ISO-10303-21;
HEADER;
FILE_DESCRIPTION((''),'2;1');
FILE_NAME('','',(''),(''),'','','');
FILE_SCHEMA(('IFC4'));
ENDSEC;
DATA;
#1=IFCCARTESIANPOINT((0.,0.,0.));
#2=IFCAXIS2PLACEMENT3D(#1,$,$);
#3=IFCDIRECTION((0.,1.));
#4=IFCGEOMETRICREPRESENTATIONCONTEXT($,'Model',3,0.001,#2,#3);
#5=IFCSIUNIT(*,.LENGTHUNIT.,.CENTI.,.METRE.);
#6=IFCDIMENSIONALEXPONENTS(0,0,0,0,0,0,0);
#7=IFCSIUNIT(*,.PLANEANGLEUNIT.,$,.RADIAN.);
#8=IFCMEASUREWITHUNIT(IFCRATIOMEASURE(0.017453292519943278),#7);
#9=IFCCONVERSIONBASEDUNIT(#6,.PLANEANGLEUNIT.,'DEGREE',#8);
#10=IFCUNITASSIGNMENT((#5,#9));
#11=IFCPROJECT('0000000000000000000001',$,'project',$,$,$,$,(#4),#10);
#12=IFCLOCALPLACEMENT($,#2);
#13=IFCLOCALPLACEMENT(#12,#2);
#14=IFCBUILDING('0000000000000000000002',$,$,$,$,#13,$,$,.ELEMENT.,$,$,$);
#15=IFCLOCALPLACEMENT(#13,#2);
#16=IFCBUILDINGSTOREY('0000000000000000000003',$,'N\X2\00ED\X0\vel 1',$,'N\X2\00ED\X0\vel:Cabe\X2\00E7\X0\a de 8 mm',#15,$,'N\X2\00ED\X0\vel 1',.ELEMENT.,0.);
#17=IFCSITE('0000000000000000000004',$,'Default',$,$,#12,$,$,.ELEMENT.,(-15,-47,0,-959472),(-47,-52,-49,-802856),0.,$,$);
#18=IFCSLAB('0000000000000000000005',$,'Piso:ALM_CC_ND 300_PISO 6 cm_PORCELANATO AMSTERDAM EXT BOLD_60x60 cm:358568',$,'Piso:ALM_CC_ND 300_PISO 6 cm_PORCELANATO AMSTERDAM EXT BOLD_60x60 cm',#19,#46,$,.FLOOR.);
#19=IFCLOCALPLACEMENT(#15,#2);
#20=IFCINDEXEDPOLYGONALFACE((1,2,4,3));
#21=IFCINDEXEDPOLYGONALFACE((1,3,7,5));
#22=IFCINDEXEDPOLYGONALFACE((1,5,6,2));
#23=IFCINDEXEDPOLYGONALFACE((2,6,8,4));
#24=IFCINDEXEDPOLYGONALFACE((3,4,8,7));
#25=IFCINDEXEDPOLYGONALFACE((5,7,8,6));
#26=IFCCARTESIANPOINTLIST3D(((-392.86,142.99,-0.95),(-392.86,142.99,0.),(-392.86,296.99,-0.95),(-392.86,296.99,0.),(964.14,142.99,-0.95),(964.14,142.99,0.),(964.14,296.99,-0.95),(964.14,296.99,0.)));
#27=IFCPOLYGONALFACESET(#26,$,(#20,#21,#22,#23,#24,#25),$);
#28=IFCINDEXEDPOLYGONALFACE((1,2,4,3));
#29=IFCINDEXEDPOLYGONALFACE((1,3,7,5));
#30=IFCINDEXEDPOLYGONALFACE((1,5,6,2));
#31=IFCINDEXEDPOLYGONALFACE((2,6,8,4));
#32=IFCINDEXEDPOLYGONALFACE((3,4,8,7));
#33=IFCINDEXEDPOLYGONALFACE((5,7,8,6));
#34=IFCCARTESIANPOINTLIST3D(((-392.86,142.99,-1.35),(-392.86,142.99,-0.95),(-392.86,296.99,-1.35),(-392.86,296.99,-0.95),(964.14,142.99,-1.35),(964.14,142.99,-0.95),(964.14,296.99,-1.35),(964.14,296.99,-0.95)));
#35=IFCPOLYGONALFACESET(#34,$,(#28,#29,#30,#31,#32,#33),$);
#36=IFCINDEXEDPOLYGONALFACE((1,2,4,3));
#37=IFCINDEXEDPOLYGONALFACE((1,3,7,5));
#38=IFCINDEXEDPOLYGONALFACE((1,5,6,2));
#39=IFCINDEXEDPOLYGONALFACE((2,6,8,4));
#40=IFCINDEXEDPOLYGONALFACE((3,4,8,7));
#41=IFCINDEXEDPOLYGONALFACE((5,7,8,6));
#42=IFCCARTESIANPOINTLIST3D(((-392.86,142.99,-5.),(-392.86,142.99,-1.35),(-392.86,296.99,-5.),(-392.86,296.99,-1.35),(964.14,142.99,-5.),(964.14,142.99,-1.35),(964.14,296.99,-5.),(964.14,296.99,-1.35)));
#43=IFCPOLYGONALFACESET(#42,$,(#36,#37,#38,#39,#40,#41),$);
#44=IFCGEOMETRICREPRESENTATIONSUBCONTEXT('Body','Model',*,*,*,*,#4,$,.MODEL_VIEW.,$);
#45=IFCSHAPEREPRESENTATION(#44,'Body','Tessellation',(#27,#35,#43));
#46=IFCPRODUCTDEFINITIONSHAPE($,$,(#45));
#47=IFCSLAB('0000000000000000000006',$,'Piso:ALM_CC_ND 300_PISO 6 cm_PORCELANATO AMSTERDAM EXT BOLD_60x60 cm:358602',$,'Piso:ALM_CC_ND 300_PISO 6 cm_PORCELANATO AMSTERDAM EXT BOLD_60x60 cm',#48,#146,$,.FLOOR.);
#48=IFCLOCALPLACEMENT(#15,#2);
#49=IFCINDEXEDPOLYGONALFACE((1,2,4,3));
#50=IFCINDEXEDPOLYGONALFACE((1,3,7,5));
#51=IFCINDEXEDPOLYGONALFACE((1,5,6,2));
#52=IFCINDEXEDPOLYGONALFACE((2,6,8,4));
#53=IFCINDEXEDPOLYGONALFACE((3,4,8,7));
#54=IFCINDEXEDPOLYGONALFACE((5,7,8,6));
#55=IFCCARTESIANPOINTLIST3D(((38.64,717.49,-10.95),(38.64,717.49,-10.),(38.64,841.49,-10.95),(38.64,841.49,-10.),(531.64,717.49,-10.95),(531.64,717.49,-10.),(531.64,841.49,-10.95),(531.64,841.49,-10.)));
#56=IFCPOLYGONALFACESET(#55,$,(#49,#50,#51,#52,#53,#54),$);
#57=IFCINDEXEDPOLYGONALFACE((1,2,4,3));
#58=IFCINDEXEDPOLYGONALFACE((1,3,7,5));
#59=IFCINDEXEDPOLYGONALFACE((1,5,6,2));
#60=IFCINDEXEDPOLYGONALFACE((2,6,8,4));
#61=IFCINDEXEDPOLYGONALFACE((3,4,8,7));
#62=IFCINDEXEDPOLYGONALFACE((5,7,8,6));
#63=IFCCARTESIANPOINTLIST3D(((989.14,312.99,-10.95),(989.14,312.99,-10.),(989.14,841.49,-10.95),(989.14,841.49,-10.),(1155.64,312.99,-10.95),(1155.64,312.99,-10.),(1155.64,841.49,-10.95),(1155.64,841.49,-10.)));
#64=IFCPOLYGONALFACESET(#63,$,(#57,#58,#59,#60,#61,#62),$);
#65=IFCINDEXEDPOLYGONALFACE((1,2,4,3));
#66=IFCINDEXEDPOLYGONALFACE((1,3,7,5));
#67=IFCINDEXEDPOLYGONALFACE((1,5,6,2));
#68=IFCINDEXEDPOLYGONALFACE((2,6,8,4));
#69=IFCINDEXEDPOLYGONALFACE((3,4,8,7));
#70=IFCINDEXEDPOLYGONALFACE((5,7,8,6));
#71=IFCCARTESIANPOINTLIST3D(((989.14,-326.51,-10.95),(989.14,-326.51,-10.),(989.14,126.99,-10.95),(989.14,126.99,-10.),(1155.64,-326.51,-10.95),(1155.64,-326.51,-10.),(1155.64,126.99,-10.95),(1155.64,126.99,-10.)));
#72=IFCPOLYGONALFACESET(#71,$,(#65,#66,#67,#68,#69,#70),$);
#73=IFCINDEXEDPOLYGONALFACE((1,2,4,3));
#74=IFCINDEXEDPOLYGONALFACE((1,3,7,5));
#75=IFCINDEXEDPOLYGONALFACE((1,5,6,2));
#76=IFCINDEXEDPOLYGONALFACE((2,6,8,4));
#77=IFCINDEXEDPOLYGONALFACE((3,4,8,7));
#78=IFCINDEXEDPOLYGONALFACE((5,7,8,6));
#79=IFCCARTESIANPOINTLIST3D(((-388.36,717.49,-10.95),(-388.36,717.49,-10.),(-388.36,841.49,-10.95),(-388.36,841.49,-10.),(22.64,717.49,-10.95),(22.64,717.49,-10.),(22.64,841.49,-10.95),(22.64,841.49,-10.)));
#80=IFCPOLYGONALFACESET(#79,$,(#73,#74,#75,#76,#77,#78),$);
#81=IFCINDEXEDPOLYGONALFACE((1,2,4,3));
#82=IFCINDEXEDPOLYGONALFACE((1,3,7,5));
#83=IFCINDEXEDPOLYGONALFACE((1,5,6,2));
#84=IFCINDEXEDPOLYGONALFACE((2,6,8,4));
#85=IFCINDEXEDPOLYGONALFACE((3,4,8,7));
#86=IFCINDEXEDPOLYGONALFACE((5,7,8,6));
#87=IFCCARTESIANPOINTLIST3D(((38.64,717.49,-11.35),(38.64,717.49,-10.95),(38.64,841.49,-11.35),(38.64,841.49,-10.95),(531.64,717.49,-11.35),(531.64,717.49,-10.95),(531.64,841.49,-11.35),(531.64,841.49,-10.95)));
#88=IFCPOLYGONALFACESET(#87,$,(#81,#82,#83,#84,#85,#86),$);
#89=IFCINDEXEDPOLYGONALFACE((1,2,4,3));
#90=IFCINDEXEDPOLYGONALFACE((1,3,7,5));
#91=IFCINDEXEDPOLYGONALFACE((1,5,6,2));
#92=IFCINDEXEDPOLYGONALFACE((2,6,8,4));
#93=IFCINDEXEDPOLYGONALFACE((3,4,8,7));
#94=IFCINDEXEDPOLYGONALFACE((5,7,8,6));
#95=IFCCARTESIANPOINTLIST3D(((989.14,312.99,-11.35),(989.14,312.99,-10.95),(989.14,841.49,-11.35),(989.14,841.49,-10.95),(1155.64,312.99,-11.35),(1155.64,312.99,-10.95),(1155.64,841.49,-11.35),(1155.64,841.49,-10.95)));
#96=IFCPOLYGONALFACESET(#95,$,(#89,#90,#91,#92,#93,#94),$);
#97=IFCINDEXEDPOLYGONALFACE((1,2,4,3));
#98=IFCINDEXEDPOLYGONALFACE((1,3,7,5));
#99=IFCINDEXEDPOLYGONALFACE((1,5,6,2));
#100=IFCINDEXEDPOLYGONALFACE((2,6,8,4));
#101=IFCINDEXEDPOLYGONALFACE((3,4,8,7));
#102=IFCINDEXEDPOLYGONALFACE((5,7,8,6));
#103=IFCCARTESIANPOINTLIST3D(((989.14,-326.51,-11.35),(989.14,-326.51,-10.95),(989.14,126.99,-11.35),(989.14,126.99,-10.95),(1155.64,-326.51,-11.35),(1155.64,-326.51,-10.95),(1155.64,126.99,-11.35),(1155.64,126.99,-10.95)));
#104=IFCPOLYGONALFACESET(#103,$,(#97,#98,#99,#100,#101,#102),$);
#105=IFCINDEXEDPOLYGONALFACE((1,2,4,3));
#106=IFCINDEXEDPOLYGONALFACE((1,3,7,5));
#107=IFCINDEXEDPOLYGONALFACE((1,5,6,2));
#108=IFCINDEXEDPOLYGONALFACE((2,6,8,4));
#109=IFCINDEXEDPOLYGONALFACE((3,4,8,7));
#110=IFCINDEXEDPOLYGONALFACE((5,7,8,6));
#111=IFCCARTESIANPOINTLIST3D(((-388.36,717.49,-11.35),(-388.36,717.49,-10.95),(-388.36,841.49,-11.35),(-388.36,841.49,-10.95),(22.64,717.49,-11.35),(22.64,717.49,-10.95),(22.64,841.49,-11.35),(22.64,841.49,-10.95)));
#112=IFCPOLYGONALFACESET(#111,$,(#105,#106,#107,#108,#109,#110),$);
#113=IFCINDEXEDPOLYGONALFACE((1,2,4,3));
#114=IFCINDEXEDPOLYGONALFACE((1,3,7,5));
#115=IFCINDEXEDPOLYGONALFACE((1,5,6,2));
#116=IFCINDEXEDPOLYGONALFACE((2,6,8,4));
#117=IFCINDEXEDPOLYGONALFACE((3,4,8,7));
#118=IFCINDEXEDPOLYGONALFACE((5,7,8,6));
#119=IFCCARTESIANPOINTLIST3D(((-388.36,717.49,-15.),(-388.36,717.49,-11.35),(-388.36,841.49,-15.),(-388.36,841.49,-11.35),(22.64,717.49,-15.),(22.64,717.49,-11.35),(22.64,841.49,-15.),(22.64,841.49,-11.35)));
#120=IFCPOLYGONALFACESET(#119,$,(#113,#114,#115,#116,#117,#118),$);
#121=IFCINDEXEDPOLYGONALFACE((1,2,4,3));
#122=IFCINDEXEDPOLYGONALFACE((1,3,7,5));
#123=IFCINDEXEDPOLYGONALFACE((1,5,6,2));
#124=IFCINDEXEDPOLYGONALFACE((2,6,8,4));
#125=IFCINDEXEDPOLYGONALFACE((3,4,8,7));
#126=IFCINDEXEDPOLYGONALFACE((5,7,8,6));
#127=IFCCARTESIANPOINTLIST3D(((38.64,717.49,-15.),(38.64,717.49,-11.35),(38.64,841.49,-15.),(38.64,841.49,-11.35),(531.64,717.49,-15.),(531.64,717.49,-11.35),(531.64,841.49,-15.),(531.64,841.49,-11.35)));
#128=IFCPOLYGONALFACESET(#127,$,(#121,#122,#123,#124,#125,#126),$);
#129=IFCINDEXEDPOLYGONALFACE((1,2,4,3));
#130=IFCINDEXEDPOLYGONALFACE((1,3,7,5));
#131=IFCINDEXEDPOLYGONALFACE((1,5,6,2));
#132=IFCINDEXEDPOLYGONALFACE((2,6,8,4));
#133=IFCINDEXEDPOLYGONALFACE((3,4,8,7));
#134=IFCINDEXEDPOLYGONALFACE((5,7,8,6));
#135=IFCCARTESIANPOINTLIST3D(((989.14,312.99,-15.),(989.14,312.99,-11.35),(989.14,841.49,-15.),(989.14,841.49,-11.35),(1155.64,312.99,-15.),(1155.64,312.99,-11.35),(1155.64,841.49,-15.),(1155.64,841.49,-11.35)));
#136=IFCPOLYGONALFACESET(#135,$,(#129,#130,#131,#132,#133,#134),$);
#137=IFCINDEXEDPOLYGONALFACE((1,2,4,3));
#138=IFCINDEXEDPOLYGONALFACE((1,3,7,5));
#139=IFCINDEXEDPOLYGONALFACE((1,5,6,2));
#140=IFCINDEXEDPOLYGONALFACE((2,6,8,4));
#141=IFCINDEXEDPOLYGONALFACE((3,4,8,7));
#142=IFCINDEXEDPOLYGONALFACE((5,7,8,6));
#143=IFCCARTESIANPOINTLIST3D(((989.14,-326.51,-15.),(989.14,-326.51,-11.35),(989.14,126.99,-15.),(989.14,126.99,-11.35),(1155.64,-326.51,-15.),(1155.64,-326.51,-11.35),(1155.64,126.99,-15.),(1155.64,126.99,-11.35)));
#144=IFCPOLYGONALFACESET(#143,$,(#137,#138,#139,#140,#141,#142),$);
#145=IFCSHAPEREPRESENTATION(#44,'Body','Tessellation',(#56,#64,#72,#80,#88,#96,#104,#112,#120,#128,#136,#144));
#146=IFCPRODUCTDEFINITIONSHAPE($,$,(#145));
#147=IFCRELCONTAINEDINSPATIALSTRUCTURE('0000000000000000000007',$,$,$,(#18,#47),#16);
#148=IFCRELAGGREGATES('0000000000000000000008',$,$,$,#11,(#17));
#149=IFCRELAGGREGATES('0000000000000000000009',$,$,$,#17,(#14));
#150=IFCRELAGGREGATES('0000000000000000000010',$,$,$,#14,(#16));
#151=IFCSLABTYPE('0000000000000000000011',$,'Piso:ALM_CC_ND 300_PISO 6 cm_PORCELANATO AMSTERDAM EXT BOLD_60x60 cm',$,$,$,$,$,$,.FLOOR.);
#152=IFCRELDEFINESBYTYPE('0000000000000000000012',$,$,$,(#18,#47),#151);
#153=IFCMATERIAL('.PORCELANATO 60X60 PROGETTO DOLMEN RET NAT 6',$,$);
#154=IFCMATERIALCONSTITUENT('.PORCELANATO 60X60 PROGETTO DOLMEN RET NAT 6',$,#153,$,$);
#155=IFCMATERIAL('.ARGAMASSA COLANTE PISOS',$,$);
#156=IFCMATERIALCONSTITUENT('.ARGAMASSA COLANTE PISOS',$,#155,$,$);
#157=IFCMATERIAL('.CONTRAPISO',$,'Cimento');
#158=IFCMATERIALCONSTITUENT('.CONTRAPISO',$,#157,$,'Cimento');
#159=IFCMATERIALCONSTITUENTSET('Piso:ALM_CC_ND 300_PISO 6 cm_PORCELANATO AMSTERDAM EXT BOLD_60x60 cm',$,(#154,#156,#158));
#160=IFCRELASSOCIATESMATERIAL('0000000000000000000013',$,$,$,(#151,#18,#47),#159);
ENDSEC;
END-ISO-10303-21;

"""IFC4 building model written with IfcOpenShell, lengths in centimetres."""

from ifc_helpers import new_model, entity, si_unit, converted_unit, direction, frame, origin, place, context, subcontext, project, spatial, indexed_curve, outline, extrude, material, constituent, constituent_set, type_object, element, save


model = new_model("IFC4")

# Units and contexts
model_context = context("Model", 3, precision=0.001, world=origin(), true_north=direction((0.0, 1.0)))
body_context = subcontext(model_context, "Body", "Model", "MODEL_VIEW")
ifc_project = project(units=[si_unit("LENGTHUNIT", "METRE", prefix="CENTI"), converted_unit("PLANEANGLEUNIT", "DEGREE", entity("IfcRatioMeasure", 0.017453292519943278), si_unit("PLANEANGLEUNIT", "RADIAN"), dimensions=[0, 0, 0, 0, 0, 0, 0])], contexts=[model_context])

# Site, building, storey
site_placement = place(None, origin())
site = spatial("IfcSite", under=ifc_project, at=site_placement, Name="Default", CompositionType="ELEMENT", RefLatitude=(-15, -47, 0, -959472), RefLongitude=(-47, -52, -49, -802856), RefElevation=0.0)
building_placement = place(site_placement, origin())
building = spatial("IfcBuilding", under=site, at=building_placement, CompositionType="ELEMENT")
storey_placement = place(building_placement, origin())
storey = spatial("IfcBuildingStorey", under=building, at=storey_placement, Name="Nível 1", ObjectType="Nível:Cabeça de 8 mm", LongName="Nível 1", CompositionType="ELEMENT", Elevation=0.0)

# Slabs
ifc_material_1 = material(Name=".PORCELANATO 60X60 PROGETTO DOLMEN RET NAT 6")
ifc_constituent_1 = constituent(ifc_material_1, Name=".PORCELANATO 60X60 PROGETTO DOLMEN RET NAT 6")
ifc_material_2 = material(Name=".ARGAMASSA COLANTE PISOS")
ifc_constituent_2 = constituent(ifc_material_2, Name=".ARGAMASSA COLANTE PISOS")
ifc_material_3 = material(Name=".CONTRAPISO", Category="Cimento")
ifc_constituent_3 = constituent(ifc_material_3, Name=".CONTRAPISO", Category="Cimento")
ifc_constituent_set_1 = constituent_set(constituents=[ifc_constituent_1, ifc_constituent_2, ifc_constituent_3], Name="Piso:ALM_CC_ND 300_PISO 6 cm_PORCELANATO AMSTERDAM EXT BOLD_60x60 cm")
slab_type_1 = type_object("IfcSlabType", Name="Piso:ALM_CC_ND 300_PISO 6 cm_PORCELANATO AMSTERDAM EXT BOLD_60x60 cm", PredefinedType="FLOOR", material=ifc_constituent_set_1)
slab_1_placement = place(storey_placement, origin())
element("IfcSlab", 1, at=slab_1_placement, inside=storey, type_object=slab_type_1, material=ifc_constituent_set_1, Name="Piso:ALM_CC_ND 300_PISO 6 cm_PORCELANATO AMSTERDAM EXT BOLD_60x60 cm:358568", ObjectType="Piso:ALM_CC_ND 300_PISO 6 cm_PORCELANATO AMSTERDAM EXT BOLD_60x60 cm", PredefinedType="FLOOR", context=body_context, shape_type="SweptSolid", body=[
    extrude(outline(indexed_curve([(-77.0, -678.5), (77.0, -678.5), (77.0, 678.5), (-77.0, 678.5), (-77.0, -678.5)], self_intersect=False)), frame((285.64, 219.99, -0.95), z_axis=(0.0, 0.0, 1.0), x_axis=(0.0, -1.0, 0.0)), (0.0, 0.0, 1.0), 0.95),
    extrude(outline(indexed_curve([(-77.0, -678.5), (77.0, -678.5), (77.0, 678.5), (-77.0, 678.5), (-77.0, -678.5)], self_intersect=False)), frame((285.64, 219.99, -1.35), z_axis=(0.0, 0.0, 1.0), x_axis=(0.0, -1.0, 0.0)), (0.0, 0.0, 1.0), 0.4),
    extrude(outline(indexed_curve([(-77.0, -678.5), (77.0, -678.5), (77.0, 678.5), (-77.0, 678.5), (-77.0, -678.5)], self_intersect=False)), frame((285.64, 219.99, -5.0), z_axis=(0.0, 0.0, 1.0), x_axis=(0.0, -1.0, 0.0)), (0.0, 0.0, 1.0), 3.65),
])
slab_2_placement = place(storey_placement, origin())
element("IfcSlab", 2, at=slab_2_placement, inside=storey, type_object=slab_type_1, material=ifc_constituent_set_1, Name="Piso:ALM_CC_ND 300_PISO 6 cm_PORCELANATO AMSTERDAM EXT BOLD_60x60 cm:358602", ObjectType="Piso:ALM_CC_ND 300_PISO 6 cm_PORCELANATO AMSTERDAM EXT BOLD_60x60 cm", PredefinedType="FLOOR", context=body_context, shape_type="SweptSolid", body=[
    extrude(outline(indexed_curve([(-62.0, -246.5), (62.0, -246.5), (62.0, 246.5), (-62.0, 246.5), (-62.0, -246.5)], self_intersect=False)), frame((285.14, 779.49, -10.95), z_axis=(0.0, 0.0, 1.0), x_axis=(0.0, -1.0, 0.0)), (0.0, 0.0, 1.0), 0.95),
    extrude(outline(indexed_curve([(-83.25, -264.25), (83.25, -264.25), (83.25, 264.25), (-83.25, 264.25), (-83.25, -264.25)], self_intersect=False)), frame((1072.39, 577.24, -10.95)), (0.0, 0.0, 1.0), 0.95),
    extrude(outline(indexed_curve([(-83.25, -226.75), (83.25, -226.75), (83.25, 226.75), (-83.25, 226.75), (-83.25, -226.75)], self_intersect=False)), frame((1072.39, -99.76, -10.95)), (0.0, 0.0, 1.0), 0.95),
    extrude(outline(indexed_curve([(-62.0, -205.5), (62.0, -205.5), (62.0, 205.5), (-62.0, 205.5), (-62.0, -205.5)], self_intersect=False)), frame((-182.86, 779.49, -10.95), z_axis=(0.0, 0.0, 1.0), x_axis=(0.0, -1.0, 0.0)), (0.0, 0.0, 1.0), 0.95),
    extrude(outline(indexed_curve([(-62.0, -246.5), (62.0, -246.5), (62.0, 246.5), (-62.0, 246.5), (-62.0, -246.5)], self_intersect=False)), frame((285.14, 779.49, -11.35), z_axis=(0.0, 0.0, 1.0), x_axis=(0.0, -1.0, 0.0)), (0.0, 0.0, 1.0), 0.4),
    extrude(outline(indexed_curve([(-83.25, -264.25), (83.25, -264.25), (83.25, 264.25), (-83.25, 264.25), (-83.25, -264.25)], self_intersect=False)), frame((1072.39, 577.24, -11.35)), (0.0, 0.0, 1.0), 0.4),
    extrude(outline(indexed_curve([(-83.25, -226.75), (83.25, -226.75), (83.25, 226.75), (-83.25, 226.75), (-83.25, -226.75)], self_intersect=False)), frame((1072.39, -99.76, -11.35)), (0.0, 0.0, 1.0), 0.4),
    extrude(outline(indexed_curve([(-62.0, -205.5), (62.0, -205.5), (62.0, 205.5), (-62.0, 205.5), (-62.0, -205.5)], self_intersect=False)), frame((-182.86, 779.49, -11.35), z_axis=(0.0, 0.0, 1.0), x_axis=(0.0, -1.0, 0.0)), (0.0, 0.0, 1.0), 0.4),
    extrude(outline(indexed_curve([(-62.0, -205.5), (62.0, -205.5), (62.0, 205.5), (-62.0, 205.5), (-62.0, -205.5)], self_intersect=False)), frame((-182.86, 779.49, -15.0), z_axis=(0.0, 0.0, 1.0), x_axis=(0.0, -1.0, 0.0)), (0.0, 0.0, 1.0), 3.65),
    extrude(outline(indexed_curve([(-62.0, -246.5), (62.0, -246.5), (62.0, 246.5), (-62.0, 246.5), (-62.0, -246.5)], self_intersect=False)), frame((285.14, 779.49, -15.0), z_axis=(0.0, 0.0, 1.0), x_axis=(0.0, -1.0, 0.0)), (0.0, 0.0, 1.0), 3.65),
    extrude(outline(indexed_curve([(-83.25, -264.25), (83.25, -264.25), (83.25, 264.25), (-83.25, 264.25), (-83.25, -264.25)], self_intersect=False)), frame((1072.39, 577.24, -15.0)), (0.0, 0.0, 1.0), 3.65),
    extrude(outline(indexed_curve([(-83.25, -226.75), (83.25, -226.75), (83.25, 226.75), (-83.25, 226.75), (-83.25, -226.75)], self_intersect=False)), frame((1072.39, -99.76, -15.0)), (0.0, 0.0, 1.0), 3.65),
])

save(model, "model.ifc")
